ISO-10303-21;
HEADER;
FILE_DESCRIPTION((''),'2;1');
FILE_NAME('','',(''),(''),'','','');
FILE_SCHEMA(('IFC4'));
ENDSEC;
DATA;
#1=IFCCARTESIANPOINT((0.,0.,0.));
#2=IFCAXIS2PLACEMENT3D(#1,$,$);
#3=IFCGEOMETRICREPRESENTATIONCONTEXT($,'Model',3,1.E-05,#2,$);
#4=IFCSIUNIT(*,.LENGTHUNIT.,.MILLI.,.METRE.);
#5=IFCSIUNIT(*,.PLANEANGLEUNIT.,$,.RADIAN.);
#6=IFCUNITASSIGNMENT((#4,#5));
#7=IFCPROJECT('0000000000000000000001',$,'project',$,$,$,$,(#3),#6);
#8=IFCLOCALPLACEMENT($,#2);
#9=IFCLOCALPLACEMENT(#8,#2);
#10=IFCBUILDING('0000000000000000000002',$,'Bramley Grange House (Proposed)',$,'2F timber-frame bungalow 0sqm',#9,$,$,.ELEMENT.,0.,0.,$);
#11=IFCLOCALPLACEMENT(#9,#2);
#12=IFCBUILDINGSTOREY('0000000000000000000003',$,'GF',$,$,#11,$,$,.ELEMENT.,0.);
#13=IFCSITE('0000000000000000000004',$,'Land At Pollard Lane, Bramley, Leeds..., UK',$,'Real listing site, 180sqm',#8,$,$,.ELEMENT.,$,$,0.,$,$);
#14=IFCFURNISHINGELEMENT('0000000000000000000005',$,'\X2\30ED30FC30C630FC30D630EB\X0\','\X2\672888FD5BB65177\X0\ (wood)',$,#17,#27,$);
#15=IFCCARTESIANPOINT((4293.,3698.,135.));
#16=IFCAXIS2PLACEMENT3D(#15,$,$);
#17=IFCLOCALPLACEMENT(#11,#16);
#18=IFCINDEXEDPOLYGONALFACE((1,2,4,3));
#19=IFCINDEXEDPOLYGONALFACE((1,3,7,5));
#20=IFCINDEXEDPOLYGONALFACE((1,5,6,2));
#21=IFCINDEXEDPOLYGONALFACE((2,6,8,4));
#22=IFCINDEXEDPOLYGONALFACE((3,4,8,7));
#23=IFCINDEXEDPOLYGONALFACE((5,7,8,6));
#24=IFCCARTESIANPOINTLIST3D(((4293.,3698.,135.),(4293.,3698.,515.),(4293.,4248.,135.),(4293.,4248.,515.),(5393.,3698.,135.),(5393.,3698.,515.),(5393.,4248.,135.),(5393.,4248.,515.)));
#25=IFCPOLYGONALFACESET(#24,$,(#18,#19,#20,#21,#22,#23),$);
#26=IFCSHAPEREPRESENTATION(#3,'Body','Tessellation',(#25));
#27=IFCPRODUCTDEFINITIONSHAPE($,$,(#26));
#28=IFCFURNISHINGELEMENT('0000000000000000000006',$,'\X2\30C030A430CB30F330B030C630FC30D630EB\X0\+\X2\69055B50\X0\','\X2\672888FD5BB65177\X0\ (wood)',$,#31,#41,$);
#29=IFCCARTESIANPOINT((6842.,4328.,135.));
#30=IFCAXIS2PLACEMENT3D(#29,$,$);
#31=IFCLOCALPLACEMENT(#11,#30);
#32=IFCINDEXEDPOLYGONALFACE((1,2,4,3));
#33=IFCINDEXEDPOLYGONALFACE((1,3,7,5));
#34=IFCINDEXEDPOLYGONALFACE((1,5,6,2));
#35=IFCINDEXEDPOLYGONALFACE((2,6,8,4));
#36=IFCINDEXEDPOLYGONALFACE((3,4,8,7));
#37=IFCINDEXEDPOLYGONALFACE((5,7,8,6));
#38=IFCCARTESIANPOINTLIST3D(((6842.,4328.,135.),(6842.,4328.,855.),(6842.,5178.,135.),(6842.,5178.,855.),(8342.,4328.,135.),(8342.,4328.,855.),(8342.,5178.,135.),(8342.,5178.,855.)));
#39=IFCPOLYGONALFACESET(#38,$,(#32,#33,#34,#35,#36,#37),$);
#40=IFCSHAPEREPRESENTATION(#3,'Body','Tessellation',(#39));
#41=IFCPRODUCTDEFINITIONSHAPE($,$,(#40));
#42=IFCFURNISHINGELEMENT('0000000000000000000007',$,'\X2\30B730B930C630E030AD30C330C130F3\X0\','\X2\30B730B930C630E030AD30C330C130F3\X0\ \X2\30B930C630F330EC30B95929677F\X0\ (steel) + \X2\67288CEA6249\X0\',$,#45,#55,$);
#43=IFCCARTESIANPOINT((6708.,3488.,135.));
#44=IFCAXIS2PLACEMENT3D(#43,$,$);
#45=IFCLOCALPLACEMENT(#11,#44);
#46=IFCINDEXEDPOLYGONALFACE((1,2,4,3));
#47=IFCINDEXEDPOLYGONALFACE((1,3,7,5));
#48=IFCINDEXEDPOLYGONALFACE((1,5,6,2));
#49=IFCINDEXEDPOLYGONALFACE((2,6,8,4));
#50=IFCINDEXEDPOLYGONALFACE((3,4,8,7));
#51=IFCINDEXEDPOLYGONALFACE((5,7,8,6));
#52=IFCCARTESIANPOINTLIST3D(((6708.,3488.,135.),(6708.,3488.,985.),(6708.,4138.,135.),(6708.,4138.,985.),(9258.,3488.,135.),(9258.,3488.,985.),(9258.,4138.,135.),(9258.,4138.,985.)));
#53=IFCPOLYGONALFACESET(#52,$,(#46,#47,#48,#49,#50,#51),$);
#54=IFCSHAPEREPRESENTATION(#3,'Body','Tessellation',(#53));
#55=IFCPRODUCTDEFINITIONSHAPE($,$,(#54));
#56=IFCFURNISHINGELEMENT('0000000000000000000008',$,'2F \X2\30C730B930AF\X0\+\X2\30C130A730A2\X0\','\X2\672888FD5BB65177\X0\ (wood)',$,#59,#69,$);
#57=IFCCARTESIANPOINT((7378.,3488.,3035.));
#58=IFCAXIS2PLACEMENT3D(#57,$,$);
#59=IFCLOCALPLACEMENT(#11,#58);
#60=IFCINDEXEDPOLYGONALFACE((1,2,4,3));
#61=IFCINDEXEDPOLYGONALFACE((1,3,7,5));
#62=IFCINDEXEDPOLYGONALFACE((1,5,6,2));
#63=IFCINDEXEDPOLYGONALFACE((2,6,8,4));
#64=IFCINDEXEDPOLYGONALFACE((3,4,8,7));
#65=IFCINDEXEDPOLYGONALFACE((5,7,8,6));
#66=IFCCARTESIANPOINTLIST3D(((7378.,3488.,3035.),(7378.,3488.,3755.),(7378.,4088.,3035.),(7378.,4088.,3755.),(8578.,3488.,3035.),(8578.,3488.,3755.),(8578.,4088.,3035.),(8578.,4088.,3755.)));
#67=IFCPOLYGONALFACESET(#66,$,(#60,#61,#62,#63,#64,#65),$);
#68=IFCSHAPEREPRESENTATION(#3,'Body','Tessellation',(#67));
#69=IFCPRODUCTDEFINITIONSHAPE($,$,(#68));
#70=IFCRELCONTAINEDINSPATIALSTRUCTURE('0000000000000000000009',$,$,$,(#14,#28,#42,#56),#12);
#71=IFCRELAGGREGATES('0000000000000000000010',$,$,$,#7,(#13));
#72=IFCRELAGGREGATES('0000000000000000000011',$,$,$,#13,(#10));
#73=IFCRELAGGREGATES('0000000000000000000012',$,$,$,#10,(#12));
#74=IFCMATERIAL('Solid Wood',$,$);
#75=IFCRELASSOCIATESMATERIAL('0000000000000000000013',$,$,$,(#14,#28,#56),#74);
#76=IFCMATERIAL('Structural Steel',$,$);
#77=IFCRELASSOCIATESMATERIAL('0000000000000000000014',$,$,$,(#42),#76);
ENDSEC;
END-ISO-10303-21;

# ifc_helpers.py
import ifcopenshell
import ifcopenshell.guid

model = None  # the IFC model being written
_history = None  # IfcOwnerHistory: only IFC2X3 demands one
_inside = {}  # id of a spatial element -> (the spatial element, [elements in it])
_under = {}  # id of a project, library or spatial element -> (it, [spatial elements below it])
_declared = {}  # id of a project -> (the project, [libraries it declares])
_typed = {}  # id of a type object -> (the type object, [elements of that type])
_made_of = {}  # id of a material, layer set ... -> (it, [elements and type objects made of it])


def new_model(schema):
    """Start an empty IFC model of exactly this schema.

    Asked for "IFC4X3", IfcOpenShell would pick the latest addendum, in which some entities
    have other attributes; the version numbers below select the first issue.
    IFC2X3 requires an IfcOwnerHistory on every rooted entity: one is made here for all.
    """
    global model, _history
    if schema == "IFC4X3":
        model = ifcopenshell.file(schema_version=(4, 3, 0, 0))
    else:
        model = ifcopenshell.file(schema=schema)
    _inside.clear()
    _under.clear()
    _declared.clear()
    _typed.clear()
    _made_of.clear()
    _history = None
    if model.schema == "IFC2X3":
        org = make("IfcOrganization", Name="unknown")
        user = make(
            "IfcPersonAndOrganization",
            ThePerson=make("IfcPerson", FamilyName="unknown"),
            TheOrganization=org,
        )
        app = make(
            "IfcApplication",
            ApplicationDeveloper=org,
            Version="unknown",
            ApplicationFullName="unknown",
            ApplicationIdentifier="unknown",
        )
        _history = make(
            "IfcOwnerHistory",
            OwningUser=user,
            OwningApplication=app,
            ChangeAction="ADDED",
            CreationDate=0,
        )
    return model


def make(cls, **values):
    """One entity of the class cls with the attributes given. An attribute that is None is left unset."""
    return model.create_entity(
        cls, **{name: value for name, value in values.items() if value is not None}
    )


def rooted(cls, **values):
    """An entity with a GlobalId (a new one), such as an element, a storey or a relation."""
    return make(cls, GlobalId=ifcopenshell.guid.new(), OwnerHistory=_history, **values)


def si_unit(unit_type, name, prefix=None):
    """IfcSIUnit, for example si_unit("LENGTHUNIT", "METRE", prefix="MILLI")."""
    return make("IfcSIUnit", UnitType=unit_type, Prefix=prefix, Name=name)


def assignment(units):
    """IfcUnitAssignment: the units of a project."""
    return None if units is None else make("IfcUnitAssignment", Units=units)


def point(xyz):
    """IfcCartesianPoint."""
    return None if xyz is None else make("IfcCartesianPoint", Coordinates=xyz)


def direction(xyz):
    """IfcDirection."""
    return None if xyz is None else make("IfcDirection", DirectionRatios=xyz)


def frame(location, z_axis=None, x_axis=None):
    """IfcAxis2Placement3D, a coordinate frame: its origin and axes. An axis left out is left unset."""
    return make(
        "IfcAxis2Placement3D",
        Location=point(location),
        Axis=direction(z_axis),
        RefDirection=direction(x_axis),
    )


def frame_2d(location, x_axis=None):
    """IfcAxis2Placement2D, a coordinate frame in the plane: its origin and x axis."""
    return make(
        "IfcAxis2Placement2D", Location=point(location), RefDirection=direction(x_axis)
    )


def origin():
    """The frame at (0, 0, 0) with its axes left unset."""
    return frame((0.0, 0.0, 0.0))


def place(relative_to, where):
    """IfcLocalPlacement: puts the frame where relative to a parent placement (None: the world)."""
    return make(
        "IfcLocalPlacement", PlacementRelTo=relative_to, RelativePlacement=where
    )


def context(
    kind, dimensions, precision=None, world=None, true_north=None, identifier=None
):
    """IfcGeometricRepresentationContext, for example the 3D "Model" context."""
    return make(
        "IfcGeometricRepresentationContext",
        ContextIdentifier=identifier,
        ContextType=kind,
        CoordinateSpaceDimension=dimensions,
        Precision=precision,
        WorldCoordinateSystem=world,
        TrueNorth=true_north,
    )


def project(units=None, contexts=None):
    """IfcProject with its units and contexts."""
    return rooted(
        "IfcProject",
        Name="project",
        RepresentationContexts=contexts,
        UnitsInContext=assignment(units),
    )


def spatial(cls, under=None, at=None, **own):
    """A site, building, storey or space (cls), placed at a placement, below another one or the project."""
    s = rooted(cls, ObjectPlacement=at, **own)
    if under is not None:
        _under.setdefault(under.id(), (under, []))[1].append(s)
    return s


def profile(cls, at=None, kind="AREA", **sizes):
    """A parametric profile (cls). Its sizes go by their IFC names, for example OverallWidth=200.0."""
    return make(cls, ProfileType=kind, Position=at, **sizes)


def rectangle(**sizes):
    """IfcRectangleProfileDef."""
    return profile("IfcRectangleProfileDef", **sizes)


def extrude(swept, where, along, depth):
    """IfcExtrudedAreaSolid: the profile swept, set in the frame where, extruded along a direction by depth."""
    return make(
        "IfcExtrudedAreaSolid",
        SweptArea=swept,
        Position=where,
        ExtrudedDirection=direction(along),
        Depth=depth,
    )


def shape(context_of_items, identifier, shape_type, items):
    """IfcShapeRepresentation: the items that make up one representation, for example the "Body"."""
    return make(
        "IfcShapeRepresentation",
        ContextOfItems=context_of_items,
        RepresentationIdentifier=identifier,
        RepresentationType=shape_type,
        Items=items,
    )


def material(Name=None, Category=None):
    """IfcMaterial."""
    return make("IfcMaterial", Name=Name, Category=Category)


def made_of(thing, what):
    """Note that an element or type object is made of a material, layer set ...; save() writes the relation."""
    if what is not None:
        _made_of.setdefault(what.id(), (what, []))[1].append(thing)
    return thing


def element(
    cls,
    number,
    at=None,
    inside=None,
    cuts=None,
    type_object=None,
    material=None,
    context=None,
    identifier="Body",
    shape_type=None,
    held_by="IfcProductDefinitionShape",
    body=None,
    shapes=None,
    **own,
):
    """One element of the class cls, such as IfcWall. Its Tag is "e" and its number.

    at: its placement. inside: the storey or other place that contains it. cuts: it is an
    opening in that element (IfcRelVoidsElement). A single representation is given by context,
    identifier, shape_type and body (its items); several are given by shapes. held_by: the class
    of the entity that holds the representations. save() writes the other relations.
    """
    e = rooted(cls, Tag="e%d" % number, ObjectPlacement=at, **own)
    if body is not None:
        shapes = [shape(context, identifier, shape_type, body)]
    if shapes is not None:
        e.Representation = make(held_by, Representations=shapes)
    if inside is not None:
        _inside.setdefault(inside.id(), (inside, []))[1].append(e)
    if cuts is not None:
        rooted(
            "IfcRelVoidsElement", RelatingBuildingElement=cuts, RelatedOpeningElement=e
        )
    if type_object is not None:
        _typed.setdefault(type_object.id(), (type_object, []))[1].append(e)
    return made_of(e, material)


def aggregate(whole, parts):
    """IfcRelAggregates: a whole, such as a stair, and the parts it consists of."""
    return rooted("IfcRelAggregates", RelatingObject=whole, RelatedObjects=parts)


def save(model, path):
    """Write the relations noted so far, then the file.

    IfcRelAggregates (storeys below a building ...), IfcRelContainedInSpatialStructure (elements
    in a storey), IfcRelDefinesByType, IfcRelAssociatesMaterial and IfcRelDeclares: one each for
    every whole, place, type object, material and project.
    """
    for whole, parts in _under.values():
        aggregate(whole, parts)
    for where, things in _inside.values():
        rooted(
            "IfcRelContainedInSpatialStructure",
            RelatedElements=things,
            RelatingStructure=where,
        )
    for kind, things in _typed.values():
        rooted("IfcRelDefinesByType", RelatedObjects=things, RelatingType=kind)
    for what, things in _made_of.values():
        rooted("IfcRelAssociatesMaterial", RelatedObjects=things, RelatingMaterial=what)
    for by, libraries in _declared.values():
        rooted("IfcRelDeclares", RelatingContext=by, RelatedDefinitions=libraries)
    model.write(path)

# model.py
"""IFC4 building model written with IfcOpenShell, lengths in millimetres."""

from ifc_helpers import new_model, si_unit, frame, frame_2d, origin, place, context, project, spatial, rectangle, extrude, material, element, save


model = new_model("IFC4")

# Units and contexts
model_context = context("Model", 3, precision=1e-05, world=origin())
ifc_project = project(units=[si_unit("LENGTHUNIT", "METRE", prefix="MILLI"), si_unit("PLANEANGLEUNIT", "RADIAN")], contexts=[model_context])

# Site, building, storey
site_placement = place(None, origin())
site = spatial("IfcSite", under=ifc_project, at=site_placement, Name="Land At Pollard Lane, Bramley, Leeds..., UK", ObjectType="Real listing site, 180sqm", CompositionType="ELEMENT", RefElevation=0.0)
building_placement = place(site_placement, origin())
building = spatial("IfcBuilding", under=site, at=building_placement, Name="Bramley Grange House (Proposed)", ObjectType="2F timber-frame bungalow 0sqm", CompositionType="ELEMENT", ElevationOfRefHeight=0.0, ElevationOfTerrain=0.0)
storey_placement = place(building_placement, origin())
storey = spatial("IfcBuildingStorey", under=building, at=storey_placement, Name="GF", CompositionType="ELEMENT", Elevation=0.0)

# Shared definitions
ifc_material_1 = material(Name="Solid Wood")

# Shared definitions
ifc_material_2 = material(Name="Structural Steel")

# Furnishing elements
furnishing_1_placement = place(storey_placement, frame((4293.0, 3698.0, 135.0)))
element("IfcFurnishingElement", 1, at=furnishing_1_placement, inside=storey, material=ifc_material_1, Name="ローテーブル", Description="木製家具 (wood)", context=model_context, shape_type="SweptSolid", body=[
    extrude(rectangle(XDim=1100.0, YDim=550.0, at=frame_2d((550.0, 275.0))), frame((4293.0, 3698.0, 135.0)), (0.0, 0.0, 1.0), 380.0),
])
furnishing_2_placement = place(storey_placement, frame((6842.0, 4328.0, 135.0)))
element("IfcFurnishingElement", 2, at=furnishing_2_placement, inside=storey, material=ifc_material_1, Name="ダイニングテーブル+椅子", Description="木製家具 (wood)", context=model_context, shape_type="SweptSolid", body=[
    extrude(rectangle(XDim=1500.0, YDim=850.0, at=frame_2d((750.0, 425.0))), frame((6842.0, 4328.0, 135.0)), (0.0, 0.0, 1.0), 720.0),
])
furnishing_3_placement = place(storey_placement, frame((6708.0, 3488.0, 135.0)))
element("IfcFurnishingElement", 3, at=furnishing_3_placement, inside=storey, material=ifc_material_2, Name="システムキッチン", Description="システムキッチン ステンレス天板 (steel) + 木質扉", context=model_context, shape_type="SweptSolid", body=[
    extrude(rectangle(XDim=2550.0, YDim=650.0, at=frame_2d((1275.0, 325.0))), frame((6708.0, 3488.0, 135.0)), (0.0, 0.0, 1.0), 850.0),
])
furnishing_4_placement = place(storey_placement, frame((7378.0, 3488.0, 3035.0)))
element("IfcFurnishingElement", 4, at=furnishing_4_placement, inside=storey, material=ifc_material_1, Name="2F デスク+チェア", Description="木製家具 (wood)", context=model_context, shape_type="SweptSolid", body=[
    extrude(rectangle(XDim=1200.0, YDim=600.0, at=frame_2d((600.0, 300.0))), frame((7378.0, 3488.0, 3035.0)), (0.0, 0.0, 1.0), 720.0),
])

save(model, "model.ifc")
